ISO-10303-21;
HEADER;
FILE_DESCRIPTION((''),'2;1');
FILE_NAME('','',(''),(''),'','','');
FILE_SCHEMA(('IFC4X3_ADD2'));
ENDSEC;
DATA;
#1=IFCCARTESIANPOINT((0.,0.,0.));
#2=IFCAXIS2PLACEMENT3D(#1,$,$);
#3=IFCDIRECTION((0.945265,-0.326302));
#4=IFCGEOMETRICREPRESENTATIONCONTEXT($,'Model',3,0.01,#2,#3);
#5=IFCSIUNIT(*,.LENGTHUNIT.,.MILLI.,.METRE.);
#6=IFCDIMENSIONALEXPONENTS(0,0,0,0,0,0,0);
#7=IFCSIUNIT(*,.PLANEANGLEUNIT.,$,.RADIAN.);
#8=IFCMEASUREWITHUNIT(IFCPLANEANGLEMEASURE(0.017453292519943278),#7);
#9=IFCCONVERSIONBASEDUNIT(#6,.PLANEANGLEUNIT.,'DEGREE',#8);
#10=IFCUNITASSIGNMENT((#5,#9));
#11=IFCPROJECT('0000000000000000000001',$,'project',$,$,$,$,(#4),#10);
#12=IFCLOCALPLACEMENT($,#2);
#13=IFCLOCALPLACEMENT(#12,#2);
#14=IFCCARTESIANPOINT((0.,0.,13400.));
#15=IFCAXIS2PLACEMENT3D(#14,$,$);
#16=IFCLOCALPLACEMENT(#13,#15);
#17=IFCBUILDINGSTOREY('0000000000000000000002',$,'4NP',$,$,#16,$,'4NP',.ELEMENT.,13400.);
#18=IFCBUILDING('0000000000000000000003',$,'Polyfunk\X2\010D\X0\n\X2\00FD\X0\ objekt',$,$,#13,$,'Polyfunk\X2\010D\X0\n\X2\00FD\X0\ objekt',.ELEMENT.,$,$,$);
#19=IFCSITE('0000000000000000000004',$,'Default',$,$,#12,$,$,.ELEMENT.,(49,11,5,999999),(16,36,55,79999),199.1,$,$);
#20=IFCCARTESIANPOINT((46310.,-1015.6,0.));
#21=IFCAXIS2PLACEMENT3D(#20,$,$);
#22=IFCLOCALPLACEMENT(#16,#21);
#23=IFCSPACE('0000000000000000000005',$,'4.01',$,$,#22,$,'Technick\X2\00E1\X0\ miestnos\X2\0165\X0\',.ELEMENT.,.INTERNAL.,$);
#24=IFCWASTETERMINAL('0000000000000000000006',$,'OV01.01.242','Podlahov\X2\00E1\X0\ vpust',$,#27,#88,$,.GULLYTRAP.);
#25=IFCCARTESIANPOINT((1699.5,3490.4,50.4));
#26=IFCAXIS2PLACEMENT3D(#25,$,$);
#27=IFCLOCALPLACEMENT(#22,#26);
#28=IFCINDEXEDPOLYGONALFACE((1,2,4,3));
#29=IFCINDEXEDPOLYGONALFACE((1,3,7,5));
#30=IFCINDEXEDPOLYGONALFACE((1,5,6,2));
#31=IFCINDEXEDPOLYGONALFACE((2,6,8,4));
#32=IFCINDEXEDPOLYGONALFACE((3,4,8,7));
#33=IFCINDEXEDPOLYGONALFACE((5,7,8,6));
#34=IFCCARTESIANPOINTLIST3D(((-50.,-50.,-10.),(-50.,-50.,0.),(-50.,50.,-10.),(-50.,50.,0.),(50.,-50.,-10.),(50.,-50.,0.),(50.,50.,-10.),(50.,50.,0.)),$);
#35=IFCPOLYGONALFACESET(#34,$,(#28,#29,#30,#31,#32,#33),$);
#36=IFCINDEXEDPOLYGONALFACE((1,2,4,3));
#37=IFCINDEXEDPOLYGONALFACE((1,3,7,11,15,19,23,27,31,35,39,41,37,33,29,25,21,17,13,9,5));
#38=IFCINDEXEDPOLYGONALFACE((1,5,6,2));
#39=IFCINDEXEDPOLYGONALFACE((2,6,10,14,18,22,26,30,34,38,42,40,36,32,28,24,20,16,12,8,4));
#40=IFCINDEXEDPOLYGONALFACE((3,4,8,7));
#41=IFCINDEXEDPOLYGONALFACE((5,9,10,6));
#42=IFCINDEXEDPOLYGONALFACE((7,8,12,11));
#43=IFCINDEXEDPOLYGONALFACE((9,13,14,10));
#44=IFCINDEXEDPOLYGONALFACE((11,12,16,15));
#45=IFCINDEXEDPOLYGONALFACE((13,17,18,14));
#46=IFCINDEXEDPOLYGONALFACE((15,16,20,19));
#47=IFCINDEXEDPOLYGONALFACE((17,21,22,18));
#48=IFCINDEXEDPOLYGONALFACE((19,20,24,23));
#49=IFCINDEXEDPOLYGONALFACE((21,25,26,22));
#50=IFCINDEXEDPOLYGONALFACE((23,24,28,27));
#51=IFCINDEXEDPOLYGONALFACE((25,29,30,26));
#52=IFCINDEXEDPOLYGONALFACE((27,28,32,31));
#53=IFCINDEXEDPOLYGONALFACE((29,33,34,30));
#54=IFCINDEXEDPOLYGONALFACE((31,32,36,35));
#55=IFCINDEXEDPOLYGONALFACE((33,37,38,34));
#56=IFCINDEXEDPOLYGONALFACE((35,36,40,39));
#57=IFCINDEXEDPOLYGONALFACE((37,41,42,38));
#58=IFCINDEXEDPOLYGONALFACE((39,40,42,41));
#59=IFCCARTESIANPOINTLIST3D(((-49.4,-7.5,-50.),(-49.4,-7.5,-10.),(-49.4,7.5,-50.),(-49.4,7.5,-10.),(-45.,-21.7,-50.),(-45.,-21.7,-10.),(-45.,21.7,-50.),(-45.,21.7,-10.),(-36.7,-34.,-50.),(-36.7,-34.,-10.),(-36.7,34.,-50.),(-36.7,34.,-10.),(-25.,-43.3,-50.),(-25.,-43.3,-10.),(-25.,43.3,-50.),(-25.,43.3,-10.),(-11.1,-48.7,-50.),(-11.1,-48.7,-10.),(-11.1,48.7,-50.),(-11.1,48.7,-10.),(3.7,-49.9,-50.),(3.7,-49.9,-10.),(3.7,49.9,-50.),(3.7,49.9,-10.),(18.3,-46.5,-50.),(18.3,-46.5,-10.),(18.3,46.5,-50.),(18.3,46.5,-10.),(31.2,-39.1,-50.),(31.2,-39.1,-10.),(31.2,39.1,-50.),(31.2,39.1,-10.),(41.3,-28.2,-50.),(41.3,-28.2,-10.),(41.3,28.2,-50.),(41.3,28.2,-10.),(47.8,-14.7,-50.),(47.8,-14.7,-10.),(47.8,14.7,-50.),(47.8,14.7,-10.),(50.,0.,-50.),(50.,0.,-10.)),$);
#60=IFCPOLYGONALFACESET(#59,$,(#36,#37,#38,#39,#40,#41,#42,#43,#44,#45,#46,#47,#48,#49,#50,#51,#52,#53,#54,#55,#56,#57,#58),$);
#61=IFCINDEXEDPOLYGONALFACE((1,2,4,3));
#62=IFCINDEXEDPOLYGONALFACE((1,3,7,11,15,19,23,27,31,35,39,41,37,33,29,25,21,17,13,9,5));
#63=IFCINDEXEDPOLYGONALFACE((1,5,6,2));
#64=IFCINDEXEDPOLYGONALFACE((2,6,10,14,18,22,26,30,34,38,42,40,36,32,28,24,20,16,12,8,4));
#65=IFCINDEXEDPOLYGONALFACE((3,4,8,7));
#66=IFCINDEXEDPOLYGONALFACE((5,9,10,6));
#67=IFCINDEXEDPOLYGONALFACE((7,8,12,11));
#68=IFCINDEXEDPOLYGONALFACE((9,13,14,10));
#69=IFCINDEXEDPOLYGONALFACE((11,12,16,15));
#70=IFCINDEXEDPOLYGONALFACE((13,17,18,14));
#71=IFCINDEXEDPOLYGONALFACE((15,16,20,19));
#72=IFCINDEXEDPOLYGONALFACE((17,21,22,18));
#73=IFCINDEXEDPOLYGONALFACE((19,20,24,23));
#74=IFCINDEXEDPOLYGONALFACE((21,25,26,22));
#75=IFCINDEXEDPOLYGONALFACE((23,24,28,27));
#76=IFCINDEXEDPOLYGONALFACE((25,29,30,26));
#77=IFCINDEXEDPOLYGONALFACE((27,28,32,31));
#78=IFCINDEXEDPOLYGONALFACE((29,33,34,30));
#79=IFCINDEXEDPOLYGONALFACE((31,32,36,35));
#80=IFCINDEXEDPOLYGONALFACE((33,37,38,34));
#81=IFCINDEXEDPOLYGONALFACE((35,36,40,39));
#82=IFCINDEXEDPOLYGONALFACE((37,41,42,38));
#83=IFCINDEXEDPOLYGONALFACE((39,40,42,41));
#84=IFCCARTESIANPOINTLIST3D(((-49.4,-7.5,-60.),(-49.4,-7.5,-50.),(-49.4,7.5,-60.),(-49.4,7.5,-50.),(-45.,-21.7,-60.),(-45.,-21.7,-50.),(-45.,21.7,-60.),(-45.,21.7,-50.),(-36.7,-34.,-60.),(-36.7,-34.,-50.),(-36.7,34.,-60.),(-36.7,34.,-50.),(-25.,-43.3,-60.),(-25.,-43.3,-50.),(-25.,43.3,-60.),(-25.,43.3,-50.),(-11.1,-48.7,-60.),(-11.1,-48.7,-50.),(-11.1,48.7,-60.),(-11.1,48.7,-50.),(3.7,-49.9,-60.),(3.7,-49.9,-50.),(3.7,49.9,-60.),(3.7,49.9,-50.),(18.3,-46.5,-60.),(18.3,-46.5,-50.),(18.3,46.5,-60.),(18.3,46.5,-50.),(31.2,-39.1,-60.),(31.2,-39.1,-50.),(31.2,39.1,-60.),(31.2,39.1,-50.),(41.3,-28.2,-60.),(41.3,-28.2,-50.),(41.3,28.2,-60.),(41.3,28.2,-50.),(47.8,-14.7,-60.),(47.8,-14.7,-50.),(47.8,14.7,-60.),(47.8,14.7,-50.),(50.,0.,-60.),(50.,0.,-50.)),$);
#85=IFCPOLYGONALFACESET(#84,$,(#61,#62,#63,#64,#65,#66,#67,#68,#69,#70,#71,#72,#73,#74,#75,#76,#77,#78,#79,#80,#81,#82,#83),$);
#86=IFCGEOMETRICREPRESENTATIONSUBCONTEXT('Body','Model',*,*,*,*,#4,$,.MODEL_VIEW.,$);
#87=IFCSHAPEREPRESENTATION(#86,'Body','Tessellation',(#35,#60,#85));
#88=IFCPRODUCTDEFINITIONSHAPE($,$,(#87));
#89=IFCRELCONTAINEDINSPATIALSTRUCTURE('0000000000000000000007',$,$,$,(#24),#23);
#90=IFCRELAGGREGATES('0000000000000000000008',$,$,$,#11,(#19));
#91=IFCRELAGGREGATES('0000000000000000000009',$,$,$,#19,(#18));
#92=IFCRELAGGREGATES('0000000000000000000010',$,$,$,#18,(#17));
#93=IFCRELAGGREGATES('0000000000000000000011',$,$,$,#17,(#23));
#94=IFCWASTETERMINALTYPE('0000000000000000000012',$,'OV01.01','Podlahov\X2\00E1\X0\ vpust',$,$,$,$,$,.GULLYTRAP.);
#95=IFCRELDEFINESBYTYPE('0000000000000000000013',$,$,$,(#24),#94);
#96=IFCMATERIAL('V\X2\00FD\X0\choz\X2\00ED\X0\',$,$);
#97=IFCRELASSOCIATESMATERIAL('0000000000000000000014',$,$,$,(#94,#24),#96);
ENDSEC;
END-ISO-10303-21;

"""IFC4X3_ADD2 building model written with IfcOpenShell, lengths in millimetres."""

from ifc_helpers import new_model, entity, si_unit, converted_unit, direction, frame, frame_2d, origin, place, context, subcontext, project, spatial, rectangle, circle, extrude, source, transform, mapped, material, type_object, type_shapes, element, save


model = new_model("IFC4X3_ADD2")

# Units and contexts
model_context = context("Model", 3, precision=0.01, world=origin(), true_north=direction((0.945265, -0.326302)))
body_context = subcontext(model_context, "Body", "Model", "MODEL_VIEW")
ifc_project = project(units=[si_unit("LENGTHUNIT", "METRE", prefix="MILLI"), converted_unit("PLANEANGLEUNIT", "DEGREE", entity("IfcPlaneAngleMeasure", 0.017453292519943278), si_unit("PLANEANGLEUNIT", "RADIAN"), dimensions=[0, 0, 0, 0, 0, 0, 0])], contexts=[model_context])

# Site, building, storey
site_placement = place(None, origin())
site = spatial("IfcSite", under=ifc_project, at=site_placement, Name="Default", CompositionType="ELEMENT", RefLatitude=(49, 11, 5, 999999), RefLongitude=(16, 36, 55, 79999), RefElevation=199.1)
building_placement = place(site_placement, origin())
building = spatial("IfcBuilding", under=site, at=building_placement, Name="Polyfunkčný objekt", LongName="Polyfunkčný objekt", CompositionType="ELEMENT")
storey_placement = place(building_placement, frame((0.0, 0.0, 13400.0)))
storey = spatial("IfcBuildingStorey", under=building, at=storey_placement, Name="4NP", LongName="4NP", CompositionType="ELEMENT", Elevation=13400.0)

# Shared definitions
ifc_material_1 = material(Name="Výchozí")

# Shared definitions
space_placement = place(storey_placement, frame((46310.0, -1015.6, 0.0)))
space = spatial("IfcSpace", under=storey, at=space_placement, Name="4.01", LongName="Technická miestnosť", CompositionType="ELEMENT", PredefinedType="INTERNAL")

# Waste terminal
waste_terminal_type = type_object("IfcWasteTerminalType", Name="OV01.01", Description="Podlahová vpust", PredefinedType="GULLYTRAP", material=ifc_material_1)
shared_shape_1 = source(origin(), body_context, "Body", "SweptSolid", [
    extrude(rectangle(XDim=100.0, YDim=100.0, at=frame_2d((0.0, 0.0), x_axis=(1.0, 0.0))), frame((0.0, 0.0, -10.0), z_axis=(0.0, 0.0, 1.0), x_axis=(-1.0, 0.0, 0.0)), (0.0, 0.0, 1.0), 10.0),
    extrude(circle(Radius=50.0, at=frame_2d((0.0, 0.0), x_axis=(1.0, 0.0))), frame((0.0, 0.0, -50.0)), (0.0, 0.0, 1.0), 40.0),
    extrude(circle(Radius=50.0, at=frame_2d((0.0, 0.0), x_axis=(1.0, 0.0))), frame((0.0, 0.0, -60.0)), (0.0, 0.0, 1.0), 10.0),
])
type_shapes(waste_terminal_type, [shared_shape_1])
waste_terminal_placement = place(space_placement, frame((1699.5, 3490.4, 50.4)))
element("IfcWasteTerminal", 1, at=waste_terminal_placement, inside=space, type_object=waste_terminal_type, material=ifc_material_1, Name="OV01.01.242", Description="Podlahová vpust", PredefinedType="GULLYTRAP", context=body_context, shape_type="MappedRepresentation", body=[
    mapped(shared_shape_1, transform((0.0, 0.0, 0.0), scale=1.0)),
])

save(model, "model.ifc")
